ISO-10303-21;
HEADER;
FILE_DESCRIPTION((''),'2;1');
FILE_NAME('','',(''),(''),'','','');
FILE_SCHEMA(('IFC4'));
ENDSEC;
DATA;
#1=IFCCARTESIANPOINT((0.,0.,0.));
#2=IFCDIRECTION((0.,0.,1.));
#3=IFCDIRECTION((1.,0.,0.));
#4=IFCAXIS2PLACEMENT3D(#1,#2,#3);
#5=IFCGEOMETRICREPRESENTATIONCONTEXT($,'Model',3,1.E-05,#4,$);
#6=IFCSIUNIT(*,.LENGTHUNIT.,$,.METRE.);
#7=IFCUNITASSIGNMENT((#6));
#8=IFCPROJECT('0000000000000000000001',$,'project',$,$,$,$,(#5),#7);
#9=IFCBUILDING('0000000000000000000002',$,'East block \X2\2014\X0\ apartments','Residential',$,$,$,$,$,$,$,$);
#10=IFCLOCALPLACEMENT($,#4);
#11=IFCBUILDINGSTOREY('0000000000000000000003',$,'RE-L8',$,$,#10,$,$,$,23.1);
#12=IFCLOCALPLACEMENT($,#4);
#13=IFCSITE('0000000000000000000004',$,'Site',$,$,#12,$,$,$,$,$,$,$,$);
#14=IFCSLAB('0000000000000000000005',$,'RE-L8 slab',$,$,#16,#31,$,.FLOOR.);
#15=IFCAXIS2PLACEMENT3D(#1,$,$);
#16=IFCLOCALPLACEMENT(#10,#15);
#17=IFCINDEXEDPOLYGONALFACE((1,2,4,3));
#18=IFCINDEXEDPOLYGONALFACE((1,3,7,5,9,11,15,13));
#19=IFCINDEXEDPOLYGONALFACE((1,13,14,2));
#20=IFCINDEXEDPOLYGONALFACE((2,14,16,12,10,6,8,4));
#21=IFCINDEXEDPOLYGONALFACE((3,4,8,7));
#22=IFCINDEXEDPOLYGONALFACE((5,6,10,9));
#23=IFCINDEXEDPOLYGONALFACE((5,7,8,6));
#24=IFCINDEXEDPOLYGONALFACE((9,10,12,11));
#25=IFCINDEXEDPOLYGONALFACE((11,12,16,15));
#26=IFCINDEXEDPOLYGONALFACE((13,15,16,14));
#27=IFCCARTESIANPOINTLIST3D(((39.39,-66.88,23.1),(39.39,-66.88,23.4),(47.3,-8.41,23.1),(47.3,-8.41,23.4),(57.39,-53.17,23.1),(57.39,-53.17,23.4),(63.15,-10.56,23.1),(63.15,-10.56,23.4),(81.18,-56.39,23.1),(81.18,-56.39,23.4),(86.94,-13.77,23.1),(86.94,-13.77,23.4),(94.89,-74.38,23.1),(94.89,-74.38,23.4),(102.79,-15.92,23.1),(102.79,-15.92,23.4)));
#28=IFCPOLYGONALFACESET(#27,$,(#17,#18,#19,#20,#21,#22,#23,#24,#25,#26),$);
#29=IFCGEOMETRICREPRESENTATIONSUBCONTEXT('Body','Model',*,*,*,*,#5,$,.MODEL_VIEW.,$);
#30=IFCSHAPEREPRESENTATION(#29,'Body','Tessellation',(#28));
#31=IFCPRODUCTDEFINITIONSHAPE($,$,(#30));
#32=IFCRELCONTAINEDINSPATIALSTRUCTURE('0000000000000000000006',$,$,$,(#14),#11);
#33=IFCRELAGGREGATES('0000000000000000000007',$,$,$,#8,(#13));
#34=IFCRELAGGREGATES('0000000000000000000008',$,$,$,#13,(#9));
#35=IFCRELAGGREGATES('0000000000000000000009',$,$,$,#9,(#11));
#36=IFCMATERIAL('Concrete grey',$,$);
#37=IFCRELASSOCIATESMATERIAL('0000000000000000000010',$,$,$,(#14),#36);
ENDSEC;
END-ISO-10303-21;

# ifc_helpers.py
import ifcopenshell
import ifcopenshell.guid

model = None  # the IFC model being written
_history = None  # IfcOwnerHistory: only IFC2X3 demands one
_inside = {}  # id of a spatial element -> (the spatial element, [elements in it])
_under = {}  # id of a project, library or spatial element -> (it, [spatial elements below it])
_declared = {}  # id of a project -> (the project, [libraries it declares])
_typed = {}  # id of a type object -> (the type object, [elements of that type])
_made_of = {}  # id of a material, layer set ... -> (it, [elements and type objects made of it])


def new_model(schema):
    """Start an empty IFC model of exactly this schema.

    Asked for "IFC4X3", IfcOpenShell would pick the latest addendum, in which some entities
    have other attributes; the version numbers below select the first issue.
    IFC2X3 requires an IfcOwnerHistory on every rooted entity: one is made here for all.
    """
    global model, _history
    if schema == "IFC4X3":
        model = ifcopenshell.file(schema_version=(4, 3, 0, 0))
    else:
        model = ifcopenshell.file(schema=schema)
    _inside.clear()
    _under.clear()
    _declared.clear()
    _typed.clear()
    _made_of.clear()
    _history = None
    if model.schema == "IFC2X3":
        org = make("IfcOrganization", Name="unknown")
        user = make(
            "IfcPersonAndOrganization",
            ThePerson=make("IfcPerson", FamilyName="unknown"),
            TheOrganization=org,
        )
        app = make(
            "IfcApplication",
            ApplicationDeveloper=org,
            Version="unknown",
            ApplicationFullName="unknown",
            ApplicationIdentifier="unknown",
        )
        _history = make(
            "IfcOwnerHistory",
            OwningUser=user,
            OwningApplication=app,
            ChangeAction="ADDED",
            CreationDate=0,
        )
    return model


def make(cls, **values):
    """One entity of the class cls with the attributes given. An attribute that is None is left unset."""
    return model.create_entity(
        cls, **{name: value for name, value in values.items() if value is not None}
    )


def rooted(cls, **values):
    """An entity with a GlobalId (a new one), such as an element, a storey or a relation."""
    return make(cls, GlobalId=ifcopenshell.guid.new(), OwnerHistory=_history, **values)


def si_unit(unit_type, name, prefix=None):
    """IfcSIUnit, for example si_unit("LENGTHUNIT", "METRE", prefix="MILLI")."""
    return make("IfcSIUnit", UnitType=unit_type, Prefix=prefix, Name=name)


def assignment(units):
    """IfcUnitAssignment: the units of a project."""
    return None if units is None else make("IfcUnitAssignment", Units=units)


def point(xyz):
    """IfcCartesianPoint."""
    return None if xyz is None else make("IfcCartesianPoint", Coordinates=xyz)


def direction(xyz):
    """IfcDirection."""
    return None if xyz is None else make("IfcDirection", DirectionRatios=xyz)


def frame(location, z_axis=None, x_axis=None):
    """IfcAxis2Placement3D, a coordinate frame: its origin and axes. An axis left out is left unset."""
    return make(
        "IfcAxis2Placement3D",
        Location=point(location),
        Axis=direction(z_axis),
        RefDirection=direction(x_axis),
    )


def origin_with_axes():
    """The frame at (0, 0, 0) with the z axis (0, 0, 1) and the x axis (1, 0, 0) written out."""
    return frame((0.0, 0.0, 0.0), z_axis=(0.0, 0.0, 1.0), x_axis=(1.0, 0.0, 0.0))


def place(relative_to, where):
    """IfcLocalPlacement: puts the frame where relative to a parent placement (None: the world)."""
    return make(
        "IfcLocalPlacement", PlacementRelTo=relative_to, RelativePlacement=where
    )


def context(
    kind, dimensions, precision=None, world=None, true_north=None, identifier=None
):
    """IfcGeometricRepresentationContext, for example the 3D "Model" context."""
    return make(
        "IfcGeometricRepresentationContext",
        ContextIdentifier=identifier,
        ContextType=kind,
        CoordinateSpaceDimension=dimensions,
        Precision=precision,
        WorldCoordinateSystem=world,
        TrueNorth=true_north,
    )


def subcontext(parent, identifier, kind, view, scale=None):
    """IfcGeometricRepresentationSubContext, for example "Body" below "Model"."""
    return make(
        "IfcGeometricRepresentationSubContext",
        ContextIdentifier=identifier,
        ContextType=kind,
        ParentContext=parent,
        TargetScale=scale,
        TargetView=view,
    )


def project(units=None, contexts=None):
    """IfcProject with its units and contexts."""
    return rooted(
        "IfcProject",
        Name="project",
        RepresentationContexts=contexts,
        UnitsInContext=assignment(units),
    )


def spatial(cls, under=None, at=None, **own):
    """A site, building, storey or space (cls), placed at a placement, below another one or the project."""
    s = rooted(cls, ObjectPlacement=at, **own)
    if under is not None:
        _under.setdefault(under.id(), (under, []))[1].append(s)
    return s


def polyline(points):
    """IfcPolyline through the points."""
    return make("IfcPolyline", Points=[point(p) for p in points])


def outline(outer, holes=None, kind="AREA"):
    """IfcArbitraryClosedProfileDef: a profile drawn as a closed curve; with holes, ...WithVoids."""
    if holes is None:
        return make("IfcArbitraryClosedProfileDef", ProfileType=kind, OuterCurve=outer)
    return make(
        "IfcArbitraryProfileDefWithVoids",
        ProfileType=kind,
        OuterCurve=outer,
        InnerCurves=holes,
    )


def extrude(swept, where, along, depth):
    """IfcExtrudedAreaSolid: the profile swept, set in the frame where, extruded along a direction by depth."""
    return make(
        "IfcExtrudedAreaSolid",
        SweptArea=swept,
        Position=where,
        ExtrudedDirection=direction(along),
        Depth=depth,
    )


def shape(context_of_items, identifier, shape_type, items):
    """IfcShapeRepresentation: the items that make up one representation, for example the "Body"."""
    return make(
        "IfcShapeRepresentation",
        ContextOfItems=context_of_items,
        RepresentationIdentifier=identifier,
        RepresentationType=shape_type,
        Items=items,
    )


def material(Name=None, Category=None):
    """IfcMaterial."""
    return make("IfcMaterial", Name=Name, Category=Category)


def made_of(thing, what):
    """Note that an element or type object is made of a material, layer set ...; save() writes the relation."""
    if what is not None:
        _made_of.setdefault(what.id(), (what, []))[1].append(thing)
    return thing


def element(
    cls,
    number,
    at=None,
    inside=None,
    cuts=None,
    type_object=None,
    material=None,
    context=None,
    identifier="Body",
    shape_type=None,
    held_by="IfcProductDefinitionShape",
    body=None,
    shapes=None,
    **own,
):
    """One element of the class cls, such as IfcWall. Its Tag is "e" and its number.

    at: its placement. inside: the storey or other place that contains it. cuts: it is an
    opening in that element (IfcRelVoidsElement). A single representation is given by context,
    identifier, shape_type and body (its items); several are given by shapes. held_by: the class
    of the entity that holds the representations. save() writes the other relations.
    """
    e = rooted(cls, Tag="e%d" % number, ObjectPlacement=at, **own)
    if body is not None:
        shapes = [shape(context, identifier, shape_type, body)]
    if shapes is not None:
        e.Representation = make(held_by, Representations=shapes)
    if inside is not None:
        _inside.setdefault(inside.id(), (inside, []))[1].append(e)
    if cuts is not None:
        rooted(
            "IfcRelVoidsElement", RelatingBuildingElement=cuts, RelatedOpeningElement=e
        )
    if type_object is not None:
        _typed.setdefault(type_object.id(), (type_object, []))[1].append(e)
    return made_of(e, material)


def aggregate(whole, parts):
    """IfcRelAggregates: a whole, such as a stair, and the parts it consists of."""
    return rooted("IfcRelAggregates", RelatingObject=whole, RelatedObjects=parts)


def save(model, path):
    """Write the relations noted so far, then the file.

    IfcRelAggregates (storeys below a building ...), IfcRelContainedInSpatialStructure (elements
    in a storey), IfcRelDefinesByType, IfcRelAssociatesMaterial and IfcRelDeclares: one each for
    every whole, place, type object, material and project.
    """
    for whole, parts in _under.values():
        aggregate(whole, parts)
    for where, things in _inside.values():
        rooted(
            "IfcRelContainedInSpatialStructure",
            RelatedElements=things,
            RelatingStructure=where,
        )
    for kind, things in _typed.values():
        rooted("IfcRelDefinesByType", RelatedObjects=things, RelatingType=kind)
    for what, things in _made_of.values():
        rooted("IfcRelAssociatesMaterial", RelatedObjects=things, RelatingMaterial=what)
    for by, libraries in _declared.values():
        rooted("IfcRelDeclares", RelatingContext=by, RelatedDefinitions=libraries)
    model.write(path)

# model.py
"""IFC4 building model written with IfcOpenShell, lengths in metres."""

from ifc_helpers import new_model, si_unit, frame, origin_with_axes, place, context, subcontext, project, spatial, polyline, outline, extrude, material, element, save


model = new_model("IFC4")

# Units and contexts
model_context = context("Model", 3, precision=1e-05, world=origin_with_axes())
body_context = subcontext(model_context, "Body", "Model", "MODEL_VIEW")
ifc_project = project(units=[si_unit("LENGTHUNIT", "METRE")], contexts=[model_context])

# Site, building, storey
site_placement = place(None, origin_with_axes())
site = spatial("IfcSite", under=ifc_project, at=site_placement, Name="Site")
building = spatial("IfcBuilding", under=site, Name="East block — apartments", Description="Residential")
storey_placement = place(None, origin_with_axes())
storey = spatial("IfcBuildingStorey", under=building, at=storey_placement, Name="RE-L8", Elevation=23.1)

# Slab
ifc_material = material(Name="Concrete grey")
slab_placement = place(storey_placement, origin_with_axes())
element("IfcSlab", 1, at=slab_placement, inside=storey, material=ifc_material, Name="RE-L8 slab", PredefinedType="FLOOR", context=body_context, shape_type="SweptSolid", body=[
    extrude(outline(polyline([(39.39, -66.88), (94.89, -74.38), (102.79, -15.92), (86.94, -13.77), (81.18, -56.39), (57.39, -53.17), (63.15, -10.56), (47.3, -8.41), (39.39, -66.88)])), frame((0.0, 0.0, 23.1), z_axis=(0.0, 0.0, 1.0), x_axis=(1.0, 0.0, 0.0)), (0.0, 0.0, 1.0), 0.3),
])

save(model, "model.ifc")
